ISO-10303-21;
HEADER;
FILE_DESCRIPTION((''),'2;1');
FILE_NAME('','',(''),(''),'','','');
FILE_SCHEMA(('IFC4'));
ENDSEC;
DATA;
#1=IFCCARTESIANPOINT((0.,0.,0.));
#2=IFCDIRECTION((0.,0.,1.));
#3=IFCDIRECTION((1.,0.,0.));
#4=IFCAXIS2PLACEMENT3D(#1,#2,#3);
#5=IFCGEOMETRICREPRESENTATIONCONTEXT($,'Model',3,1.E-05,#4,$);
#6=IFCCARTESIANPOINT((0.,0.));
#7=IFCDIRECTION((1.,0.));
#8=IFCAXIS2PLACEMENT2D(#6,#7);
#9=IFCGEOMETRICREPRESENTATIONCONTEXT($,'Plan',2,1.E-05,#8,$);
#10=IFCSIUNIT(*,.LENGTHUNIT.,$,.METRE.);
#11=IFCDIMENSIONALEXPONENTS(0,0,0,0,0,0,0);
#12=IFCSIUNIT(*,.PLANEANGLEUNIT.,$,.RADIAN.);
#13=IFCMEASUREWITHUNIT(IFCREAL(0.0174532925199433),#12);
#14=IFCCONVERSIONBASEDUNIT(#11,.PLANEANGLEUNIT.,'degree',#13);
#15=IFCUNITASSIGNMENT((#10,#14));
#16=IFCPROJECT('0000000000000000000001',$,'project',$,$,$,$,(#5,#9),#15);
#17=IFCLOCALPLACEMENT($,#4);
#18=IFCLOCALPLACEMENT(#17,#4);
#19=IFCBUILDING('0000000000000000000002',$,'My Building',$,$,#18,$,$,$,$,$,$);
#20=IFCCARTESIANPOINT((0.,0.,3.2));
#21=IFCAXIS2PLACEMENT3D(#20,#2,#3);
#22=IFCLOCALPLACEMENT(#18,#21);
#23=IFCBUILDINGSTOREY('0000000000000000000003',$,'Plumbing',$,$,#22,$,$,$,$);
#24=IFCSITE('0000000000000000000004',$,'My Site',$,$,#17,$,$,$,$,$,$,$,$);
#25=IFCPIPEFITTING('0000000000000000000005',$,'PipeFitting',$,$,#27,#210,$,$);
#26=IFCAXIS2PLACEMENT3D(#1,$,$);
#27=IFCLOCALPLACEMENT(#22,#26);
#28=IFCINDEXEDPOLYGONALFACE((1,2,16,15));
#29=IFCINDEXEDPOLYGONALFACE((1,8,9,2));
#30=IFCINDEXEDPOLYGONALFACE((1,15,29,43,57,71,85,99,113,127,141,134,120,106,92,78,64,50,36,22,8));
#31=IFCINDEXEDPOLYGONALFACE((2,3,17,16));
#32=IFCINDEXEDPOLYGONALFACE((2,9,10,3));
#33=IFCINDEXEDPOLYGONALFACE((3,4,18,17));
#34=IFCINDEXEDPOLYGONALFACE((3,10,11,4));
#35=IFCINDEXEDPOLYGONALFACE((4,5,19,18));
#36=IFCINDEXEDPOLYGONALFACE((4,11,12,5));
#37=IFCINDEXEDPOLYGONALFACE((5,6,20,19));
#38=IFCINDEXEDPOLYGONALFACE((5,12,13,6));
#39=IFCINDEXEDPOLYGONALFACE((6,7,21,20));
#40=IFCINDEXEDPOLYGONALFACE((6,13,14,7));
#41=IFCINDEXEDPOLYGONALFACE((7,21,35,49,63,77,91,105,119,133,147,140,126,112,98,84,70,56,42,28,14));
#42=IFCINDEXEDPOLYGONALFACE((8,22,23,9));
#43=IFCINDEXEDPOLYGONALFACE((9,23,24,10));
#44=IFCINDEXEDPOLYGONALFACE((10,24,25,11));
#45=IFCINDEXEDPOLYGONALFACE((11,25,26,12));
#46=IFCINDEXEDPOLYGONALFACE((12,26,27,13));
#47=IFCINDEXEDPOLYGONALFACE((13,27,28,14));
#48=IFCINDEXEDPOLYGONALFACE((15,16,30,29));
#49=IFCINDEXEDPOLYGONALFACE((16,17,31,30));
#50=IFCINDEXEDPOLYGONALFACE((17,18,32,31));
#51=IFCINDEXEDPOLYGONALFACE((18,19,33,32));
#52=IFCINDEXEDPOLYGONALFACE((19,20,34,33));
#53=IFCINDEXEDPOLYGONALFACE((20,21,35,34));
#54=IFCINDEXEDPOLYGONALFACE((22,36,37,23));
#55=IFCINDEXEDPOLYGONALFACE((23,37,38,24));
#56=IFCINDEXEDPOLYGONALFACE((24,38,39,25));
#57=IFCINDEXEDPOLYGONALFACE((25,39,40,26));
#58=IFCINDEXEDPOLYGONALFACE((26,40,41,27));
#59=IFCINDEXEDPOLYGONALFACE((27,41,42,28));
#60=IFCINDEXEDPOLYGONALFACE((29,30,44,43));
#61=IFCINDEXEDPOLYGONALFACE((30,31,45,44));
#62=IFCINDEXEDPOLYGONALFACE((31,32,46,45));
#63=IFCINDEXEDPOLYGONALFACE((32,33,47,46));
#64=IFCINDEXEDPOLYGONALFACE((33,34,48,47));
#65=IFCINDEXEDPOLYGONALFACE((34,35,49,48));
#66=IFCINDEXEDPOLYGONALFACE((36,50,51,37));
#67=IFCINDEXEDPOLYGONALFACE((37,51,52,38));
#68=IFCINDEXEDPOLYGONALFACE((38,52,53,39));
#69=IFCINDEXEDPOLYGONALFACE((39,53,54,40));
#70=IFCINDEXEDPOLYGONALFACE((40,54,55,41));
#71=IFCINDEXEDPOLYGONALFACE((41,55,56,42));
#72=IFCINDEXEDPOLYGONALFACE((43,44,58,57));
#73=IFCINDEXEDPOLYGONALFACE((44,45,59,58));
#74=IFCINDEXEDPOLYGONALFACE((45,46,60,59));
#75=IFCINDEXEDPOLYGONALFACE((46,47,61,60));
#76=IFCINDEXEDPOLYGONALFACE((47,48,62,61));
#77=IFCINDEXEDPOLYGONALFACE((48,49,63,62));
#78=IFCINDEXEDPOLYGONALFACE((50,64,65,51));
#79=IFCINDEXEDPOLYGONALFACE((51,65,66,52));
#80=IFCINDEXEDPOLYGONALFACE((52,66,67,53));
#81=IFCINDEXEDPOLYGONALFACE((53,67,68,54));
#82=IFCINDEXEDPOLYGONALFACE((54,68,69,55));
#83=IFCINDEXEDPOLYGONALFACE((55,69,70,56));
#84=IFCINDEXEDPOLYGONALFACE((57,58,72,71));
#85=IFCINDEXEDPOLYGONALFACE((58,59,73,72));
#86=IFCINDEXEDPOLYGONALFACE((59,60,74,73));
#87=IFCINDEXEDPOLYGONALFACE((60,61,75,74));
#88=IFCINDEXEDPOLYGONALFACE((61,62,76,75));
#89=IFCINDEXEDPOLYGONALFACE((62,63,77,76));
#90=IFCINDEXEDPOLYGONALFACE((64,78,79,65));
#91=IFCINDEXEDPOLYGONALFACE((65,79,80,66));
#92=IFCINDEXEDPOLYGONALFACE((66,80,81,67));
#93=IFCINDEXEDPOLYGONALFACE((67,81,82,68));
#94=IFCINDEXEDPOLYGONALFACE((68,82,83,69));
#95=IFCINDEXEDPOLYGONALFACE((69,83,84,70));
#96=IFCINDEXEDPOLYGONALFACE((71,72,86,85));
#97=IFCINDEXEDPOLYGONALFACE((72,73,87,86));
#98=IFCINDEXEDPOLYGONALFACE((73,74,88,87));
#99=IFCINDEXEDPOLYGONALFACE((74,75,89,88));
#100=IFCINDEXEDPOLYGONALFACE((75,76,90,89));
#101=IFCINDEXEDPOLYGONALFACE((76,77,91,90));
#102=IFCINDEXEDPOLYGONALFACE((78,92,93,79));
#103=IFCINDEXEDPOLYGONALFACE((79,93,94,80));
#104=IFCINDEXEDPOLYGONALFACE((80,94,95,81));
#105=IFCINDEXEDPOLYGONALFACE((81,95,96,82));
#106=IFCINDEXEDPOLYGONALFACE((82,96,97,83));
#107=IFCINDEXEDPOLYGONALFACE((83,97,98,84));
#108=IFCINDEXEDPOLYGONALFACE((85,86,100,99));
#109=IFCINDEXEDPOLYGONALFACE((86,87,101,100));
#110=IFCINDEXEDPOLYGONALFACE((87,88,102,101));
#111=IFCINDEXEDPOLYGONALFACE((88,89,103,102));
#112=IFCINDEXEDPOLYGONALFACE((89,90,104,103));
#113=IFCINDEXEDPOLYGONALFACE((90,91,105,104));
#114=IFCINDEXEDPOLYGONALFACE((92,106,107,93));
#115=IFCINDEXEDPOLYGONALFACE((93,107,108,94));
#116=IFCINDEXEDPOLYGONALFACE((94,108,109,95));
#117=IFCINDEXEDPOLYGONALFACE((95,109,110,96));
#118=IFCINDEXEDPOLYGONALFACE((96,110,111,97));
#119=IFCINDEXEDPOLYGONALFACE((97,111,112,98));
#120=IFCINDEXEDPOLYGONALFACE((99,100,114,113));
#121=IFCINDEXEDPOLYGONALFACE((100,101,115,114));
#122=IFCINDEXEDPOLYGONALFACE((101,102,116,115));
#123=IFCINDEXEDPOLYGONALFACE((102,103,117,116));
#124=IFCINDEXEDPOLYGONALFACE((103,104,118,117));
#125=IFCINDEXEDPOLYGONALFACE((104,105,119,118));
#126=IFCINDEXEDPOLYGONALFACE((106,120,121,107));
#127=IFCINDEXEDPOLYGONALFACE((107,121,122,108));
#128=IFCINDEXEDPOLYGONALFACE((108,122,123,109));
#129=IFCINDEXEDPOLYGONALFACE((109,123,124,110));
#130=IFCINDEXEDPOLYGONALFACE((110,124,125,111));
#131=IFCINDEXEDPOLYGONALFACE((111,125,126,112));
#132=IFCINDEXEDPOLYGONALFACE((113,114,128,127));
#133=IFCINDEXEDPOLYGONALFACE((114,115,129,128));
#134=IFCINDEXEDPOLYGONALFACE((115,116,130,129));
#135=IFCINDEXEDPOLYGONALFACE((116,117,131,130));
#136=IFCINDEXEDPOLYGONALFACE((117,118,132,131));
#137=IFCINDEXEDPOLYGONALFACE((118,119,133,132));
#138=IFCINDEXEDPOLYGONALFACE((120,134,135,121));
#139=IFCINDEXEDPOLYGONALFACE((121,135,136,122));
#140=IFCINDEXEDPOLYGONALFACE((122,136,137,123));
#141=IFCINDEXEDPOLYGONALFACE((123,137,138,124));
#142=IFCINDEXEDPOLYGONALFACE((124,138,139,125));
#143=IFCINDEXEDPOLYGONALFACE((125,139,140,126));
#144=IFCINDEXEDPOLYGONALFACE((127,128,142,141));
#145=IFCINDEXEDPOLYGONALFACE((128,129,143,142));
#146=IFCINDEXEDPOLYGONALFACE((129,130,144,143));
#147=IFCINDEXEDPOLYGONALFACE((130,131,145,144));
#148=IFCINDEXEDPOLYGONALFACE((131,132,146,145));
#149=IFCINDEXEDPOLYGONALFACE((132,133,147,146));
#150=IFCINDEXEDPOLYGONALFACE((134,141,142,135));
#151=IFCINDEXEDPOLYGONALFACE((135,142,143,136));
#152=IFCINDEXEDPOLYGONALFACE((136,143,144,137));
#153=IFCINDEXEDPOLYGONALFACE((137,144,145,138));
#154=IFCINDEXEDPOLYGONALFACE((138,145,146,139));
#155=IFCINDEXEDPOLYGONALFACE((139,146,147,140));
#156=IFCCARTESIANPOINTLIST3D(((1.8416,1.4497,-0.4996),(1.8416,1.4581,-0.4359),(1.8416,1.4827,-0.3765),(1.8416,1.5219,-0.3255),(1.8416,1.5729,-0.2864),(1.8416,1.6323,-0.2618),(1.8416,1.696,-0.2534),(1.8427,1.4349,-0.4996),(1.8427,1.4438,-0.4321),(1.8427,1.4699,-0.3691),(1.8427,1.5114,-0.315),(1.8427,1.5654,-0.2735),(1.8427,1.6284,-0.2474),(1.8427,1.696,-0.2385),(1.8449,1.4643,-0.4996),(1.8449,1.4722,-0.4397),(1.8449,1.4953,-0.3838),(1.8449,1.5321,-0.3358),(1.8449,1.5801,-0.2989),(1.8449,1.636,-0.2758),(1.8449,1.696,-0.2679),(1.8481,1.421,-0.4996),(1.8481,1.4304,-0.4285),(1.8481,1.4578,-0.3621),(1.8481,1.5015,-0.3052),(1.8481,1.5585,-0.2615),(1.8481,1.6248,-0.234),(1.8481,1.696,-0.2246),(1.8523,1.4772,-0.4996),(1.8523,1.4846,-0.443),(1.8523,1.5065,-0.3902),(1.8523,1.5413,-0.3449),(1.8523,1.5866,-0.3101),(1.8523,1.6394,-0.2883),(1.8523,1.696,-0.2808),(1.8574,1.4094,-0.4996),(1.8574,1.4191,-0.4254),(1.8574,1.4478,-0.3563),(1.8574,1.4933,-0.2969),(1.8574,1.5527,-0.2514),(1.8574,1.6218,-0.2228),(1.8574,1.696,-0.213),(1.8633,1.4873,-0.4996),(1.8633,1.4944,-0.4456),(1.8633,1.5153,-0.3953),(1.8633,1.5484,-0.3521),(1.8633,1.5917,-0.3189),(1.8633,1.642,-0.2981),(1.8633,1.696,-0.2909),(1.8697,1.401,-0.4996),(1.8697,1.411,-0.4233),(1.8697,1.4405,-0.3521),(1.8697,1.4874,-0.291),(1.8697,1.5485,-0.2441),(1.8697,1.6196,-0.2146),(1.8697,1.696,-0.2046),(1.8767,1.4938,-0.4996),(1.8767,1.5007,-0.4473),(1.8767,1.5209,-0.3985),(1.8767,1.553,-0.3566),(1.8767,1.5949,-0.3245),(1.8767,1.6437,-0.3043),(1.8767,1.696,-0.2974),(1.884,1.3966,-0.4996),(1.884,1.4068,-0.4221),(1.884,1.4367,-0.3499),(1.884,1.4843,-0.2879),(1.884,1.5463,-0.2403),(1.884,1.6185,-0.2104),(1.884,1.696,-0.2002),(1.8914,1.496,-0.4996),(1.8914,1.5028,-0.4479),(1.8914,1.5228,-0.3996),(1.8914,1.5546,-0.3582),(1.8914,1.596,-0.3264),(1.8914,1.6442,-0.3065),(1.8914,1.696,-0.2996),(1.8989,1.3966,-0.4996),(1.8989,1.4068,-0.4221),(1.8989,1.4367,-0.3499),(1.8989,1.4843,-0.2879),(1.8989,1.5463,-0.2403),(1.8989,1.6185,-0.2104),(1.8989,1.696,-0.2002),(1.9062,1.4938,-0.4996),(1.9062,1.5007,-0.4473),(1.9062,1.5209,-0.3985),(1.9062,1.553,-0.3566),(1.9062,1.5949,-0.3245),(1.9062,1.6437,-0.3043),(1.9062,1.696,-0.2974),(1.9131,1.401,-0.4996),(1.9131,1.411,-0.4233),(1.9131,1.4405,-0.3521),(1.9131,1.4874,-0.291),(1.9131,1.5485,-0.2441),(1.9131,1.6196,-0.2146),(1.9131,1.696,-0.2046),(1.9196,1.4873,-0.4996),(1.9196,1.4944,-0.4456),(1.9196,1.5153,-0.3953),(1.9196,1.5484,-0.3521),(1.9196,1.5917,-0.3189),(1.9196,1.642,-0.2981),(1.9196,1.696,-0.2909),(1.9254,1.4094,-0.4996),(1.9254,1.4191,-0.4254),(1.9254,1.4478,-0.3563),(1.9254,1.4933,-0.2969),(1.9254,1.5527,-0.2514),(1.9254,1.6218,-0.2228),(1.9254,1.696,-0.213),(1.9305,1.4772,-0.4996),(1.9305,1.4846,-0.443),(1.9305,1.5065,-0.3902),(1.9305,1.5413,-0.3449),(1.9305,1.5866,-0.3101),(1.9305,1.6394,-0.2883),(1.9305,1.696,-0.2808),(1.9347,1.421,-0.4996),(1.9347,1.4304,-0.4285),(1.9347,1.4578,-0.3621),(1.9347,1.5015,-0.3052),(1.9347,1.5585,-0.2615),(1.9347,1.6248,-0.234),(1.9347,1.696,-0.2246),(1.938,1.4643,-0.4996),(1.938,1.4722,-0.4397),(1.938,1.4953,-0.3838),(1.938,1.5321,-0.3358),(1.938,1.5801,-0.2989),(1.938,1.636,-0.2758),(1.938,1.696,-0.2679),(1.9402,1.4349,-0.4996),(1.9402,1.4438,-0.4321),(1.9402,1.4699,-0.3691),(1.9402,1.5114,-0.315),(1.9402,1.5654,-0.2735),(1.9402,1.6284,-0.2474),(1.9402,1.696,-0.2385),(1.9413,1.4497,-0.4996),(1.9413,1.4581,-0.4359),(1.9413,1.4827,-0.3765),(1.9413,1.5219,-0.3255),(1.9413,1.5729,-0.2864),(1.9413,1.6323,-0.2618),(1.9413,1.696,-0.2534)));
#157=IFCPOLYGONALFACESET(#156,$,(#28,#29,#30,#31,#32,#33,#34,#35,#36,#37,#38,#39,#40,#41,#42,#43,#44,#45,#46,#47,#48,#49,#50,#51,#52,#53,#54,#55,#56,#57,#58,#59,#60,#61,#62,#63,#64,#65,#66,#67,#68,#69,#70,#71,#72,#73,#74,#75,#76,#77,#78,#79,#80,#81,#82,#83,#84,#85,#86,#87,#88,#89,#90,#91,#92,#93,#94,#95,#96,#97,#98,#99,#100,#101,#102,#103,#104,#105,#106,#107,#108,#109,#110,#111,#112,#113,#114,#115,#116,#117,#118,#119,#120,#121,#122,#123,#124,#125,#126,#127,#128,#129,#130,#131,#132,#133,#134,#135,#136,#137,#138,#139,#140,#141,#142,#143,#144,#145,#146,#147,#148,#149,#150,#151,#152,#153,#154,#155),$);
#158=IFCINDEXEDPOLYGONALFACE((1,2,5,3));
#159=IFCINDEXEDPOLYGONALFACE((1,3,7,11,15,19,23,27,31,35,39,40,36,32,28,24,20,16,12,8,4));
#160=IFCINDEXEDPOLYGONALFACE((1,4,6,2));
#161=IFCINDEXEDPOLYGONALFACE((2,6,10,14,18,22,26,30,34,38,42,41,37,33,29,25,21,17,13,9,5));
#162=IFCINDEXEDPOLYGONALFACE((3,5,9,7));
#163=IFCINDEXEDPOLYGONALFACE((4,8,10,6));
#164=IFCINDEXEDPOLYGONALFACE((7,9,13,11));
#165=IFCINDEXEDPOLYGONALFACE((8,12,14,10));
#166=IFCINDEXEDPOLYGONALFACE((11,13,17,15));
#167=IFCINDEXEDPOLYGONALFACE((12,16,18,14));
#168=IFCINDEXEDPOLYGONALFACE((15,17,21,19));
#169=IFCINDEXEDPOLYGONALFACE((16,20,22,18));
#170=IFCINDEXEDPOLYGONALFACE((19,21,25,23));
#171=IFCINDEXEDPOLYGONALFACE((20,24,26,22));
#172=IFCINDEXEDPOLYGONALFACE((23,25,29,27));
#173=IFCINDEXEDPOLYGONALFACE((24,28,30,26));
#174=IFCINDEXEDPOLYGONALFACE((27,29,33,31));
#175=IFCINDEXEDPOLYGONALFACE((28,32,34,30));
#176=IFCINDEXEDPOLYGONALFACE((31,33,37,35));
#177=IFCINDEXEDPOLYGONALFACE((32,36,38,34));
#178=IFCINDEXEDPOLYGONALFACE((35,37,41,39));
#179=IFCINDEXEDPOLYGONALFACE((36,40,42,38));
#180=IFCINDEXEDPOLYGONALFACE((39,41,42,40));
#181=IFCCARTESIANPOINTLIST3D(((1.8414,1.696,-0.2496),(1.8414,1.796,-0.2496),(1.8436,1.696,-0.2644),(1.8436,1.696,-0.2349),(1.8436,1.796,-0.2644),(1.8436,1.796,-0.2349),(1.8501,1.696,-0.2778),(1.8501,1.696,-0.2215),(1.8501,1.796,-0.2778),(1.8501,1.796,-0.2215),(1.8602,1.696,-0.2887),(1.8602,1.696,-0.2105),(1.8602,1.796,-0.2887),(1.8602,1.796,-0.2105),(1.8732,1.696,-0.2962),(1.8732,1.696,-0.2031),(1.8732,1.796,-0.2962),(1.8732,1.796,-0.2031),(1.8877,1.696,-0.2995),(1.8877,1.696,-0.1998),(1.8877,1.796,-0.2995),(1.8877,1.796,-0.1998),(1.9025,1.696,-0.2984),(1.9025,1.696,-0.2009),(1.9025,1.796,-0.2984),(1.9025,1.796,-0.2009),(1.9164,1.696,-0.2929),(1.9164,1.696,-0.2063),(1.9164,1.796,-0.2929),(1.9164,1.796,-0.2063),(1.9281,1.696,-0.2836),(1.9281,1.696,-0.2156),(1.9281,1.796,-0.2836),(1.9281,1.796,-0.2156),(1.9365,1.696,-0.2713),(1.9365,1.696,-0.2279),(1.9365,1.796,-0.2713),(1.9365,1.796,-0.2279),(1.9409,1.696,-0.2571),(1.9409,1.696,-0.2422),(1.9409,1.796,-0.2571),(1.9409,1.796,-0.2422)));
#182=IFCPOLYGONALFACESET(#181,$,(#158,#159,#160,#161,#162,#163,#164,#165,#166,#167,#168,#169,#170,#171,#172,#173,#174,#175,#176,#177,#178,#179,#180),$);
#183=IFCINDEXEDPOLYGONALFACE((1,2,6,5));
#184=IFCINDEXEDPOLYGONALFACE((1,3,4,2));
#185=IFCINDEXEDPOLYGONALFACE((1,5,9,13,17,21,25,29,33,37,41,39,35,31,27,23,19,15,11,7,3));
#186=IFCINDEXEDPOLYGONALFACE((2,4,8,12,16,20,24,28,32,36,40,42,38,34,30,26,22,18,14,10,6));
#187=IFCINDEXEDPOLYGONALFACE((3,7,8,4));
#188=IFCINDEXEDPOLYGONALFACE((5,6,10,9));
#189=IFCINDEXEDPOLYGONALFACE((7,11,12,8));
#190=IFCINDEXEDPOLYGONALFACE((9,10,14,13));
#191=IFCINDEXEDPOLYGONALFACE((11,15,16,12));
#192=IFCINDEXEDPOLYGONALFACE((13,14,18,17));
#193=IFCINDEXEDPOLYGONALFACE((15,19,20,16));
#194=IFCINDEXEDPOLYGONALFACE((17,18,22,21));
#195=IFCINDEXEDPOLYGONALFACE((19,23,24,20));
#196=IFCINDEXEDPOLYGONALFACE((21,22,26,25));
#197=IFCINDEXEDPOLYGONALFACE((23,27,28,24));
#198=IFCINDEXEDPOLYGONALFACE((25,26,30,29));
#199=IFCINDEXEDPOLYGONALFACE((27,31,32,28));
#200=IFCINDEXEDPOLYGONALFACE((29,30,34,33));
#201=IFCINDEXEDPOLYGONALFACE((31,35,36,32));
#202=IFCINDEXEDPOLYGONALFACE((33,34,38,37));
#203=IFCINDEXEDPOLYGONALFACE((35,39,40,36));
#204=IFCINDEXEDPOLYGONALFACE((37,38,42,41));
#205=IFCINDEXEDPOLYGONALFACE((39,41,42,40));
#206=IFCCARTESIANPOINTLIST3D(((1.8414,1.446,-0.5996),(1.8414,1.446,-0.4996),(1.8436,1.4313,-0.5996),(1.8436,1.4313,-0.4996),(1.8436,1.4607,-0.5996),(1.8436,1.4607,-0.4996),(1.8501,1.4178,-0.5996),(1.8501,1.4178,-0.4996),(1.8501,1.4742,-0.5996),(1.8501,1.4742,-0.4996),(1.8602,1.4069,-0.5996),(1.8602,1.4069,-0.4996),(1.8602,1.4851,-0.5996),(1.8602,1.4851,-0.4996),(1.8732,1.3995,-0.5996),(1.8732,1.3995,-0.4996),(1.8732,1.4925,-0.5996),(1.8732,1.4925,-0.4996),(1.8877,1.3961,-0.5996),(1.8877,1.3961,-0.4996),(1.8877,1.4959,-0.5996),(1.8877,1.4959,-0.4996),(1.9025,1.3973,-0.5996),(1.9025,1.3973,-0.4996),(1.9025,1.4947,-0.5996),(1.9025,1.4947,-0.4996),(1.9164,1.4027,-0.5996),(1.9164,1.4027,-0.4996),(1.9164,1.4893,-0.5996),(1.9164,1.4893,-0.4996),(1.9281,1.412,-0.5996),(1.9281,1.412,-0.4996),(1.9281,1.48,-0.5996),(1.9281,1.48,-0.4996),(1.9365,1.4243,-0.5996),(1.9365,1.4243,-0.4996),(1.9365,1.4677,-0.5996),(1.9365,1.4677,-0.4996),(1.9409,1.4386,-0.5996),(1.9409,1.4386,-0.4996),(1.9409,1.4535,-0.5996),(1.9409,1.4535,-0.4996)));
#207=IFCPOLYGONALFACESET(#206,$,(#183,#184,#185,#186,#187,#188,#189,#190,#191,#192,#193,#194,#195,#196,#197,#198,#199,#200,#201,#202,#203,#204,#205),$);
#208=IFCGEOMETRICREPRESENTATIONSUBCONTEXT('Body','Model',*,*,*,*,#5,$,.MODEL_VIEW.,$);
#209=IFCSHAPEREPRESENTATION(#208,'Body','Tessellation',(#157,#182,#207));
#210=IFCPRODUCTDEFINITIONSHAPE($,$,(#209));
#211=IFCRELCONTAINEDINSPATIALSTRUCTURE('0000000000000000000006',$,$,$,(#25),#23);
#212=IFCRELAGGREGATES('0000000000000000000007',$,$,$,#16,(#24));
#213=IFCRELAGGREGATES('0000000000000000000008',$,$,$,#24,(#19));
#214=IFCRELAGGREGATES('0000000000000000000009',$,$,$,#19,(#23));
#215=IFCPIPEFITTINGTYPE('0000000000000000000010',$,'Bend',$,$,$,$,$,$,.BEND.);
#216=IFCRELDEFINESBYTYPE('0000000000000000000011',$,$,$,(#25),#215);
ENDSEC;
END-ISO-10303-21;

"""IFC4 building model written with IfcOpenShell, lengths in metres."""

from ifc_helpers import new_model, entity, si_unit, converted_unit, frame, origin_with_axes, origin_2d_with_axis, place, context, subcontext, project, spatial, circle, extrude, source, transform, mapped, type_object, type_shapes, element, save


model = new_model("IFC4")

# Units and contexts
model_context = context("Model", 3, precision=1e-05, world=origin_with_axes())
plan_context = context("Plan", 2, precision=1e-05, world=origin_2d_with_axis())
body_context = subcontext(model_context, "Body", "Model", "MODEL_VIEW")
ifc_project = project(units=[si_unit("LENGTHUNIT", "METRE"), converted_unit("PLANEANGLEUNIT", "degree", entity("IfcReal", 0.0174532925199433), si_unit("PLANEANGLEUNIT", "RADIAN"), dimensions=[0, 0, 0, 0, 0, 0, 0])], contexts=[model_context, plan_context])

# Site, building, storey
site_placement = place(None, origin_with_axes())
site = spatial("IfcSite", under=ifc_project, at=site_placement, Name="My Site")
building_placement = place(site_placement, origin_with_axes())
building = spatial("IfcBuilding", under=site, at=building_placement, Name="My Building")
storey_placement = place(building_placement, frame((0.0, 0.0, 3.2), z_axis=(0.0, 0.0, 1.0), x_axis=(1.0, 0.0, 0.0)))
storey = spatial("IfcBuildingStorey", under=building, at=storey_placement, Name="Plumbing")

# Pipe fitting
pipe_fitting_type = type_object("IfcPipeFittingType", Name="Bend", PredefinedType="BEND")
shared_shape = source(origin_with_axes(), body_context, "Body", "SolidModel", [
    entity("IfcSweptDiskSolid", entity("IfcIndexedPolyCurve", entity("IfcCartesianPointList3D", [[0.0, 0.0, -0.1], [0.0, -0.0732, -0.2768], [0.0, -0.25, -0.35]]), [entity("IfcArcIndex", [1, 2, 3])]), 0.05),
    extrude(circle(Radius=0.05), origin_with_axes(), (0.0, 0.0, -1.0), 0.1),
    extrude(circle(Radius=0.05), frame((0.0, -0.25, -0.35), z_axis=(0.0, -1.0, 0.0), x_axis=(1.0, 0.0, 0.0)), (0.0, 0.0, 1.0), 0.1),
])
type_shapes(pipe_fitting_type, [shared_shape])
for number, where, z_axis, x_axis, name in (
    (1, (1.8914, 1.796, -0.2496), (0.0, 1.0, 0.0), (-1.0, 0.0, 0.0), "PipeFitting"),
):
    element("IfcPipeFitting", number, at=place(storey_placement, frame(where, z_axis=z_axis, x_axis=x_axis)), inside=storey, type_object=pipe_fitting_type, Name=name, context=body_context, shape_type="MappedRepresentation", body=[
        mapped(shared_shape, transform((0.0, 0.0, 0.0), x_axis=(1.0, 0.0, 0.0), y_axis=(0.0, 1.0, 0.0), z_axis=(0.0, 0.0, 1.0), scale=1.0)),
    ])

save(model, "model.ifc")
